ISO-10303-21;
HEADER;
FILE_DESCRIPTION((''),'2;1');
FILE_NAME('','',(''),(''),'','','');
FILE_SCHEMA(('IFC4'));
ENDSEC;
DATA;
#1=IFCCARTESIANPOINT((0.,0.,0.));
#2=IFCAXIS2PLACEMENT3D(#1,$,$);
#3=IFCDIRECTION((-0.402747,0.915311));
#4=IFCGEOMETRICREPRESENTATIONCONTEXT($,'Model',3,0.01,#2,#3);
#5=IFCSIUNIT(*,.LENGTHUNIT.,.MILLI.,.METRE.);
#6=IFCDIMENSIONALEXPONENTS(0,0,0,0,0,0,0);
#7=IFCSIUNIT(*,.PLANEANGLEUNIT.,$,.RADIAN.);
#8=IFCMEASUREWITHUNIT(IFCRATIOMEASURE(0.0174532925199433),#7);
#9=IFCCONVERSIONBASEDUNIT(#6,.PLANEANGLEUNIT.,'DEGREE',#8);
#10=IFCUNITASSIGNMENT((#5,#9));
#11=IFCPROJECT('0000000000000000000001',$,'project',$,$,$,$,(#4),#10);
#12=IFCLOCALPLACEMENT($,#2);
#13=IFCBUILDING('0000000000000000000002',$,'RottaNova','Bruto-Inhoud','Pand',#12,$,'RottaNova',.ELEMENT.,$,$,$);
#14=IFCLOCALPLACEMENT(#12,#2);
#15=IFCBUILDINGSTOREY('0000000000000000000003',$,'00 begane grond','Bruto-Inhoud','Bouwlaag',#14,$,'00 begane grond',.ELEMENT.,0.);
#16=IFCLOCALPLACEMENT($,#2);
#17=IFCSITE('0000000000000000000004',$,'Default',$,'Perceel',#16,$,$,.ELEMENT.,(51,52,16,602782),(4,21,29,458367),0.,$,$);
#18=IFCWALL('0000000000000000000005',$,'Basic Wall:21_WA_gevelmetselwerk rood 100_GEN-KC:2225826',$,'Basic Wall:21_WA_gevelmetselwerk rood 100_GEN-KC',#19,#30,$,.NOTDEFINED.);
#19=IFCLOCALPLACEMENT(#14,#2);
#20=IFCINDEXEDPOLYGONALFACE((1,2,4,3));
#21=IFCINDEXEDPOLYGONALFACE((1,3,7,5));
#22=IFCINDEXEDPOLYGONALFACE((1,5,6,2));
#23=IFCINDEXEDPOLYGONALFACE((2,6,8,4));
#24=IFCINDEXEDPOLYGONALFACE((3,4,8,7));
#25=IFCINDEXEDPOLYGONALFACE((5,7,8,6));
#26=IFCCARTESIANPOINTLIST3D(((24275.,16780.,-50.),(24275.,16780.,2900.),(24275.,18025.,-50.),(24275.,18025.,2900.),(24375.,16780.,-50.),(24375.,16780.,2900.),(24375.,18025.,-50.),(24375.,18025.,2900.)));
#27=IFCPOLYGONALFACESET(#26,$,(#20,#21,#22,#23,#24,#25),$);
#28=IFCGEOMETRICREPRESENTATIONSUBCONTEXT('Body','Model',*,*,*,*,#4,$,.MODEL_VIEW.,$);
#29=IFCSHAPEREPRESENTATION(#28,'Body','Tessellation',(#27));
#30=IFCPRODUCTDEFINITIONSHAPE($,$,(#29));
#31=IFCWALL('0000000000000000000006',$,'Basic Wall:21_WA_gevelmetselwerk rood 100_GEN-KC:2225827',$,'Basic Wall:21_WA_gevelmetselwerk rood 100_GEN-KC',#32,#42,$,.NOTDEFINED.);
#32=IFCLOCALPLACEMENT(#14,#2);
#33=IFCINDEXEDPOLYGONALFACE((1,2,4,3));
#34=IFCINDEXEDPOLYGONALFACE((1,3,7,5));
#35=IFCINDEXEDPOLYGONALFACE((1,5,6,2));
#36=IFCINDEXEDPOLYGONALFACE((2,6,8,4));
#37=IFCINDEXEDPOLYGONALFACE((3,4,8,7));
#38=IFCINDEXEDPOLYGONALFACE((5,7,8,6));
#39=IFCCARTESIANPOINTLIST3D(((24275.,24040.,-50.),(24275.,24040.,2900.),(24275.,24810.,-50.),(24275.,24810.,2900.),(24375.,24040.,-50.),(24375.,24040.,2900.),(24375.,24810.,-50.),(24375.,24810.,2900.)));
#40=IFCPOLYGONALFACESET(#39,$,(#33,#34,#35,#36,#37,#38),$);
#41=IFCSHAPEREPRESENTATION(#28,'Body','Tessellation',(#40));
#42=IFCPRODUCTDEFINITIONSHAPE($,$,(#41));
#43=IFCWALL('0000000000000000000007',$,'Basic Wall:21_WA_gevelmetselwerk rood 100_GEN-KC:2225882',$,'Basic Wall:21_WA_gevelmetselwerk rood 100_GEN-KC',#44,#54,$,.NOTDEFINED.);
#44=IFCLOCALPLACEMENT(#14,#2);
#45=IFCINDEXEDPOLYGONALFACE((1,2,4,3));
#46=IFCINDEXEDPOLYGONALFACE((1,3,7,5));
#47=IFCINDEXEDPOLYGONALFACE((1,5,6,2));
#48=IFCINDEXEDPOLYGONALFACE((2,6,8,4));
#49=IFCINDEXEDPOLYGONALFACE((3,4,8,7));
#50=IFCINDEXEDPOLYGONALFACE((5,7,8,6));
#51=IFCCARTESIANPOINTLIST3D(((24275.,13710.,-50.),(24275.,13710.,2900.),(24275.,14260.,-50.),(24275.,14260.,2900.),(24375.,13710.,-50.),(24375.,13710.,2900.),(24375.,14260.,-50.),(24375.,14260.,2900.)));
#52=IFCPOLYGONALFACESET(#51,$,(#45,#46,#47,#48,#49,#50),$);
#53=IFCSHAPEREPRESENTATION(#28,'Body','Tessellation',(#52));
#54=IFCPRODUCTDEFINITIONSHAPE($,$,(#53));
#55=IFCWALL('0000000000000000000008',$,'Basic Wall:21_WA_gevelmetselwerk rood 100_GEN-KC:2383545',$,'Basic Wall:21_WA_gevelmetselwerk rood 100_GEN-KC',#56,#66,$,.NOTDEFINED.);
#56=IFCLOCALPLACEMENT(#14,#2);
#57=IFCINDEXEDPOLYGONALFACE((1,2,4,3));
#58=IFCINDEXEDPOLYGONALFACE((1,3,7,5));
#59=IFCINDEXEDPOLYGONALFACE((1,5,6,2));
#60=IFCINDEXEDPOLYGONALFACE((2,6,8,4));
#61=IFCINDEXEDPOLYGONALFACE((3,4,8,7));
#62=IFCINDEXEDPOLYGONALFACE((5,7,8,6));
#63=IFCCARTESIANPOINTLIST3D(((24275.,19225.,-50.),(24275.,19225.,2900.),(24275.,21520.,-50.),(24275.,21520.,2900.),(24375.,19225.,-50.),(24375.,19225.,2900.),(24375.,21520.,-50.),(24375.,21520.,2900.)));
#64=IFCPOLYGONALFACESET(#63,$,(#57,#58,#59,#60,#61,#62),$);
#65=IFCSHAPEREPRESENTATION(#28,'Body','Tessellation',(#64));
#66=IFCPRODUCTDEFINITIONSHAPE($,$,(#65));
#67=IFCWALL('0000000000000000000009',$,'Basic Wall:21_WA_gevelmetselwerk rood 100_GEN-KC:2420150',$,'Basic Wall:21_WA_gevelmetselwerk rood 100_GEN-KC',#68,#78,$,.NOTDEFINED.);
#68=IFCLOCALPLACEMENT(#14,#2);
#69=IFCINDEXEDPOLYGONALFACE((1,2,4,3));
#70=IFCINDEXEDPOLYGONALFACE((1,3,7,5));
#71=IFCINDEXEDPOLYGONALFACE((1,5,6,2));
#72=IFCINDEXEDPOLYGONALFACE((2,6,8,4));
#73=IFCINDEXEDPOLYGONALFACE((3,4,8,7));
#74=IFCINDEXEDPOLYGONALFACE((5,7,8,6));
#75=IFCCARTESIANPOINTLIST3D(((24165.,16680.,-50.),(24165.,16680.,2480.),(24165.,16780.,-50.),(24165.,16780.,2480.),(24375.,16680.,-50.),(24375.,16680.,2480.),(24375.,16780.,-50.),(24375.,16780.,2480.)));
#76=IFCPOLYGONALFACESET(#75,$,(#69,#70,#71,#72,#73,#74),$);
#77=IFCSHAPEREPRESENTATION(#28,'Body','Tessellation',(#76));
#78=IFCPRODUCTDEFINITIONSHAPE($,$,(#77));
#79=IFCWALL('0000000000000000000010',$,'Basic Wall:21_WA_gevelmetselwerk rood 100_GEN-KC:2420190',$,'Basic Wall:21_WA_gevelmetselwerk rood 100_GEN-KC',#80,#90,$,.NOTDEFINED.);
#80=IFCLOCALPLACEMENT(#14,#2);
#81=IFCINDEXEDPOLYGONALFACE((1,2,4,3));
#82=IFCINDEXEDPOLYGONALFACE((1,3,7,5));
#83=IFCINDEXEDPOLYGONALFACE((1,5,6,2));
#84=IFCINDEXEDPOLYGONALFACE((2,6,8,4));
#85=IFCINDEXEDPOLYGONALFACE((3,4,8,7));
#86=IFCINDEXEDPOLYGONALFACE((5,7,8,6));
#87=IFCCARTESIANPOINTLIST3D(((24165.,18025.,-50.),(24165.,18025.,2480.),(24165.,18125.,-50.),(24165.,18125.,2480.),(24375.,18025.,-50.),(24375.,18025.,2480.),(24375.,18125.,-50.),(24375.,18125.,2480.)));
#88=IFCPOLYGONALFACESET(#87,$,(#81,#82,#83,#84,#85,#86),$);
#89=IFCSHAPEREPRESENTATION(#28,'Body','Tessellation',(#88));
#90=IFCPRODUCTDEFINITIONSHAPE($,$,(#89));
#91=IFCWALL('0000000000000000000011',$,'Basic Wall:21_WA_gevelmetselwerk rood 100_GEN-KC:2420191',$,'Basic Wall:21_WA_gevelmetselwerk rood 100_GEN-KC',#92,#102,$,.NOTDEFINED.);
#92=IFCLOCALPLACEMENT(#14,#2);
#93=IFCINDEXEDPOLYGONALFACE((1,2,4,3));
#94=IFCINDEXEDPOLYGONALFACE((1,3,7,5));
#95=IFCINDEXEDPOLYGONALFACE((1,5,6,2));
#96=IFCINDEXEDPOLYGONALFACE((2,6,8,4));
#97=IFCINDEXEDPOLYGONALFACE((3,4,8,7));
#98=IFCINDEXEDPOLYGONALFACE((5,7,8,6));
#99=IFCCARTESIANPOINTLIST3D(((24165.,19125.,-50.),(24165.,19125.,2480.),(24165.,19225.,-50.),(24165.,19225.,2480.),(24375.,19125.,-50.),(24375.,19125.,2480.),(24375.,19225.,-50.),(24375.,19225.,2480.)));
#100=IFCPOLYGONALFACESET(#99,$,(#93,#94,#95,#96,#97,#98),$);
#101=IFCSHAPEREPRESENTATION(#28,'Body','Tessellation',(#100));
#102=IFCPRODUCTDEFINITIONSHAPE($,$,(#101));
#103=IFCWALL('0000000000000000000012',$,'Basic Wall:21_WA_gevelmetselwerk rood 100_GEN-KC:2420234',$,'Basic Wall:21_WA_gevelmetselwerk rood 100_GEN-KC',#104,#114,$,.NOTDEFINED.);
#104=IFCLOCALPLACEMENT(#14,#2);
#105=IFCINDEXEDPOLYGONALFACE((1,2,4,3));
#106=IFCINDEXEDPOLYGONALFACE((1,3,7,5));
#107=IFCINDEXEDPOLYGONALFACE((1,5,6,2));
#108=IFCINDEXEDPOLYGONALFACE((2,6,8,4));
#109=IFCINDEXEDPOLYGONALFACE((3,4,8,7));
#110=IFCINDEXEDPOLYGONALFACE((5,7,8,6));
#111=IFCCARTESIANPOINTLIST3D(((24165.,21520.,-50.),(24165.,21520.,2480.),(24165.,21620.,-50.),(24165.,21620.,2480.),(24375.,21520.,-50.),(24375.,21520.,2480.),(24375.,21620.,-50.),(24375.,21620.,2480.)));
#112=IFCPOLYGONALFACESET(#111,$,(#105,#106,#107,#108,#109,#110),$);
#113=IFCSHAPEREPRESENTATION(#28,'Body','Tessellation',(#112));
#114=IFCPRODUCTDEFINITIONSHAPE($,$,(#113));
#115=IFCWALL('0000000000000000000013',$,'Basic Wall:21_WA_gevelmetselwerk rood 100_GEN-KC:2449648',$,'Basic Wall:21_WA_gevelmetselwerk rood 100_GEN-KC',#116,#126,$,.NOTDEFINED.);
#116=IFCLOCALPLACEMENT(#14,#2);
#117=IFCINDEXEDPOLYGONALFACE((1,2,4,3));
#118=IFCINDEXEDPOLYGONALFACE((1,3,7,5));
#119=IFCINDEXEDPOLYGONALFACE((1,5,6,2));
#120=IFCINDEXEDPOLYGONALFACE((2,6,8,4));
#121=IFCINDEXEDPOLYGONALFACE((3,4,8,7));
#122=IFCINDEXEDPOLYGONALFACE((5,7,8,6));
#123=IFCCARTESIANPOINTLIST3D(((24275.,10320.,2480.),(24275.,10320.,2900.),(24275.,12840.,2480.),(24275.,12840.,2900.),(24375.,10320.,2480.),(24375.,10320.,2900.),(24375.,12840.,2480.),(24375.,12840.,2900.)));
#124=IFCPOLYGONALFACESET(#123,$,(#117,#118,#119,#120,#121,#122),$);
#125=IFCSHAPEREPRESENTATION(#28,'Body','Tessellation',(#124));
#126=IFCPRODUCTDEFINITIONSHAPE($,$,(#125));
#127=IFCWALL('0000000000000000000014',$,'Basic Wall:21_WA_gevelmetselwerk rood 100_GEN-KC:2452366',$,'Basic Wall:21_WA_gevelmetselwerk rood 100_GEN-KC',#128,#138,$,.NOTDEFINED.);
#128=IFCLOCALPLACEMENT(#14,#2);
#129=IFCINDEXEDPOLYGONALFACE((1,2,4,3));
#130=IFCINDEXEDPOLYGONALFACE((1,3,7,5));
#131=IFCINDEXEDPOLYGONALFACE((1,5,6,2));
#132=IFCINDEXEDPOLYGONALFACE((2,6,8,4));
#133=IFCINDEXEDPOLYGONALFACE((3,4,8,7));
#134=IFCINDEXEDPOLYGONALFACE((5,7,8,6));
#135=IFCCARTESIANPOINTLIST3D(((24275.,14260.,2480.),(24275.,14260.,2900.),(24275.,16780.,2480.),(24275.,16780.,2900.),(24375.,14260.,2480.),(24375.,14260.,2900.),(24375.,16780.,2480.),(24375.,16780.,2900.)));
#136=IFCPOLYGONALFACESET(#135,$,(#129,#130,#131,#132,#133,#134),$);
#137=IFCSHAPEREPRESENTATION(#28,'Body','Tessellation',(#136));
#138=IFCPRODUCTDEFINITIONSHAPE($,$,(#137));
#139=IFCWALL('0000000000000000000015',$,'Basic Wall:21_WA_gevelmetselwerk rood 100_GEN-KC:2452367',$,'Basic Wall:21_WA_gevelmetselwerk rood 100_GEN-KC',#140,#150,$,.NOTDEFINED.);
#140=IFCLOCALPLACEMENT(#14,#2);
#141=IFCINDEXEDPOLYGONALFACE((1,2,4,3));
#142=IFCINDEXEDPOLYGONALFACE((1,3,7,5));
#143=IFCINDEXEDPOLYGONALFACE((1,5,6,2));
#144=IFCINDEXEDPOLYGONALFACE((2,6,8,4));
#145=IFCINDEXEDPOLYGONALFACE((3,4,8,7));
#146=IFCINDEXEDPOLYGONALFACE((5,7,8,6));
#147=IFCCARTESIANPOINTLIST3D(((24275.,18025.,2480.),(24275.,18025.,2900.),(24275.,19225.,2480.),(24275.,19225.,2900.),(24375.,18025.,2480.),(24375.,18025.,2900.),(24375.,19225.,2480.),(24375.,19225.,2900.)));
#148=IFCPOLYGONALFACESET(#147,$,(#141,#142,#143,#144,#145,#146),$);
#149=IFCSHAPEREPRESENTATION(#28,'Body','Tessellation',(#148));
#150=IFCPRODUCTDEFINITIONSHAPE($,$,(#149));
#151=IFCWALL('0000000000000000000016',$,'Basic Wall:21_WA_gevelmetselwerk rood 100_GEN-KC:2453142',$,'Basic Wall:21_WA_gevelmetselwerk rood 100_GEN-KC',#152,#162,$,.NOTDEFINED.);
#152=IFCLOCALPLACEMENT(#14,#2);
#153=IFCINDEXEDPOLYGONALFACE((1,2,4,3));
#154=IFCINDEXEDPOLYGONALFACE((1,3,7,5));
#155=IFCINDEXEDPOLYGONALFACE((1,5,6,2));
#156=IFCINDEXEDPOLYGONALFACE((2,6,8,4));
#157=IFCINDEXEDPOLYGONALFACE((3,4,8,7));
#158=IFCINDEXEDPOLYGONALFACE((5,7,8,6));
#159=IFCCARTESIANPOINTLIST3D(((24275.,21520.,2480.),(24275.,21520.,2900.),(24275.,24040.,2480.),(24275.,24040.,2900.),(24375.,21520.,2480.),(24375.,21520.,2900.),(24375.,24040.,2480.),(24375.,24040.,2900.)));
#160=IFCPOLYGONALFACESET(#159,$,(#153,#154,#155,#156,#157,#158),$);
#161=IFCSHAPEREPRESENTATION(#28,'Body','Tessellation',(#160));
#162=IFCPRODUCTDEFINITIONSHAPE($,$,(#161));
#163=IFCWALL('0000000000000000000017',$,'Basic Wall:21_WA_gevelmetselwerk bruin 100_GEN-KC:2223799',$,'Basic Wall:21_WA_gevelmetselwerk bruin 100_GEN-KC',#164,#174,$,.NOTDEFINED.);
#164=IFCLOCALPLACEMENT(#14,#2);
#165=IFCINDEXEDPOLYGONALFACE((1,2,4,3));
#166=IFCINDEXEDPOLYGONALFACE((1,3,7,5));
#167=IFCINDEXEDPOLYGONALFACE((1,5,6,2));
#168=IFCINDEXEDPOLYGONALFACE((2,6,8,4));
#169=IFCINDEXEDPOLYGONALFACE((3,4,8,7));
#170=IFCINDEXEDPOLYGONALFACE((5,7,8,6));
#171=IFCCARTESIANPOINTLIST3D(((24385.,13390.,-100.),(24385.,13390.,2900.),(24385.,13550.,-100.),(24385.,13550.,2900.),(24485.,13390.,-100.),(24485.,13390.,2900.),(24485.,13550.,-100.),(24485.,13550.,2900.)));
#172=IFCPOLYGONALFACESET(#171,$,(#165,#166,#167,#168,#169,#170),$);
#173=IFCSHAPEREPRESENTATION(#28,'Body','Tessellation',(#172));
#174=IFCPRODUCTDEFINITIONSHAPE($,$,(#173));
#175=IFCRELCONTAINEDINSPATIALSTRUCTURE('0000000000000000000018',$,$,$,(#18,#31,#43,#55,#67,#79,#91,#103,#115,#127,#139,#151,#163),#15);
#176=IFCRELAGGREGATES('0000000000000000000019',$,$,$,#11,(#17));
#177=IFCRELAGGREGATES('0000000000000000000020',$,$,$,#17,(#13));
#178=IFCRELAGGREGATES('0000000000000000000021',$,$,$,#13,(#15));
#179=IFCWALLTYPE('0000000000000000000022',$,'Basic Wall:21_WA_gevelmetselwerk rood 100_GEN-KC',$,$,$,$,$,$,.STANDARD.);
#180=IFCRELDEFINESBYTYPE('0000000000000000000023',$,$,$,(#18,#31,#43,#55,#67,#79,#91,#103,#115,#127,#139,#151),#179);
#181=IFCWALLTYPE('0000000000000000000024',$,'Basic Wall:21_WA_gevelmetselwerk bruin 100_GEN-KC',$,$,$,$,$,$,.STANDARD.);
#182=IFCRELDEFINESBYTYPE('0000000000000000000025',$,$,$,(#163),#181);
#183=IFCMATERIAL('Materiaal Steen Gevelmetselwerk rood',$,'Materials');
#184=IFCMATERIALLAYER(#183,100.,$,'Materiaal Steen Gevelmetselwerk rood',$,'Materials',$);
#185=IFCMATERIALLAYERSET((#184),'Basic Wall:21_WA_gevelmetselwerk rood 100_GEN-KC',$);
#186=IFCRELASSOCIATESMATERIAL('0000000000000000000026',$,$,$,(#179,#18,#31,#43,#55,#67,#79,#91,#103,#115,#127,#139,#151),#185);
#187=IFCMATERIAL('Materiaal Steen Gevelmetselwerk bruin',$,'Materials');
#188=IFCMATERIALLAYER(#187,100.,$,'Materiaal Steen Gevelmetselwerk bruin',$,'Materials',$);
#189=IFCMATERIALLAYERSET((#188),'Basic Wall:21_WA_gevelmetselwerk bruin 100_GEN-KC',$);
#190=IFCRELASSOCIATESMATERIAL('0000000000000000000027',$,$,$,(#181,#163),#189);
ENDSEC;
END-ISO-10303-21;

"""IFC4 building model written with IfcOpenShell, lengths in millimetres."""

from ifc_helpers import new_model, entity, si_unit, converted_unit, direction, frame, frame_2d, origin, place, context, subcontext, project, spatial, polyline, rectangle, extrude, clip, bounded_halfspace, material, layer, layer_set, type_object, element, save


model = new_model("IFC4")

# Units and contexts
model_context = context("Model", 3, precision=0.01, world=origin(), true_north=direction((-0.402747, 0.915311)))
body_context = subcontext(model_context, "Body", "Model", "MODEL_VIEW")
ifc_project = project(units=[si_unit("LENGTHUNIT", "METRE", prefix="MILLI"), converted_unit("PLANEANGLEUNIT", "DEGREE", entity("IfcRatioMeasure", 0.0174532925199433), si_unit("PLANEANGLEUNIT", "RADIAN"), dimensions=[0, 0, 0, 0, 0, 0, 0])], contexts=[model_context])

# Site, building, storey
site_placement = place(None, origin())
site = spatial("IfcSite", under=ifc_project, at=site_placement, Name="Default", ObjectType="Perceel", CompositionType="ELEMENT", RefLatitude=(51, 52, 16, 602782), RefLongitude=(4, 21, 29, 458367), RefElevation=0.0)
building_placement = place(None, origin())
building = spatial("IfcBuilding", under=site, at=building_placement, Name="RottaNova", Description="Bruto-Inhoud", ObjectType="Pand", LongName="RottaNova", CompositionType="ELEMENT")
storey_placement = place(building_placement, origin())
storey = spatial("IfcBuildingStorey", under=building, at=storey_placement, Name="00 begane grond", Description="Bruto-Inhoud", ObjectType="Bouwlaag", LongName="00 begane grond", CompositionType="ELEMENT", Elevation=0.0)

# Walls
ifc_material_1 = material(Name="Materiaal Steen Gevelmetselwerk rood", Category="Materials")
ifc_layer_1 = layer(ifc_material_1, 100.0, Name="Materiaal Steen Gevelmetselwerk rood", Category="Materials")
ifc_layer_set_1 = layer_set([ifc_layer_1], Name="Basic Wall:21_WA_gevelmetselwerk rood 100_GEN-KC")
wall_type_1 = type_object("IfcWallType", Name="Basic Wall:21_WA_gevelmetselwerk rood 100_GEN-KC", PredefinedType="STANDARD", material=ifc_layer_set_1)
wall_1_placement = place(storey_placement, frame((24325.0, 16780.0, -50.0), z_axis=(0.0, 0.0, 1.0), x_axis=(0.0, 1.0, 0.0)))
element("IfcWall", 1, at=wall_1_placement, inside=storey, type_object=wall_type_1, material=ifc_layer_set_1, Name="Basic Wall:21_WA_gevelmetselwerk rood 100_GEN-KC:2225826", ObjectType="Basic Wall:21_WA_gevelmetselwerk rood 100_GEN-KC", PredefinedType="NOTDEFINED", context=body_context, shape_type="SweptSolid", body=[
    extrude(rectangle(XDim=1245.0, YDim=100.0, at=frame_2d((622.5, 0.0), x_axis=(-1.0, 0.0))), origin(), (0.0, 0.0, 1.0), 2950.0),
])
wall_2_placement = place(storey_placement, frame((24325.0, 24810.0, -50.0), z_axis=(0.0, 0.0, 1.0), x_axis=(0.0, -1.0, 0.0)))
element("IfcWall", 2, at=wall_2_placement, inside=storey, type_object=wall_type_1, material=ifc_layer_set_1, Name="Basic Wall:21_WA_gevelmetselwerk rood 100_GEN-KC:2225827", ObjectType="Basic Wall:21_WA_gevelmetselwerk rood 100_GEN-KC", PredefinedType="NOTDEFINED", context=body_context, shape_type="SweptSolid", body=[
    extrude(rectangle(XDim=770.0, YDim=100.0, at=frame_2d((385.0, 0.0), x_axis=(-1.0, 0.0))), origin(), (0.0, 0.0, 1.0), 2950.0),
])
wall_3_placement = place(storey_placement, frame((24325.0, 13710.0, -50.0), z_axis=(0.0, 0.0, 1.0), x_axis=(0.0, 1.0, 0.0)))
element("IfcWall", 3, at=wall_3_placement, inside=storey, type_object=wall_type_1, material=ifc_layer_set_1, Name="Basic Wall:21_WA_gevelmetselwerk rood 100_GEN-KC:2225882", ObjectType="Basic Wall:21_WA_gevelmetselwerk rood 100_GEN-KC", PredefinedType="NOTDEFINED", context=body_context, shape_type="SweptSolid", body=[
    extrude(rectangle(XDim=550.0, YDim=100.0, at=frame_2d((275.0, 0.0), x_axis=(-1.0, 0.0))), origin(), (0.0, 0.0, 1.0), 2950.0),
])
wall_4_placement = place(storey_placement, frame((24325.0, 19225.0, -50.0), z_axis=(0.0, 0.0, 1.0), x_axis=(0.0, 1.0, 0.0)))
element("IfcWall", 4, at=wall_4_placement, inside=storey, type_object=wall_type_1, material=ifc_layer_set_1, Name="Basic Wall:21_WA_gevelmetselwerk rood 100_GEN-KC:2383545", ObjectType="Basic Wall:21_WA_gevelmetselwerk rood 100_GEN-KC", PredefinedType="NOTDEFINED", context=body_context, shape_type="SweptSolid", body=[
    extrude(rectangle(XDim=2295.0, YDim=100.0, at=frame_2d((1147.5, 0.0), x_axis=(-1.0, 0.0))), origin(), (0.0, 0.0, 1.0), 2950.0),
])
wall_5_placement = place(storey_placement, frame((24375.0, 16730.0, -50.0), z_axis=(0.0, 0.0, 1.0), x_axis=(-1.0, 0.0, 0.0)))
element("IfcWall", 5, at=wall_5_placement, inside=storey, type_object=wall_type_1, material=ifc_layer_set_1, Name="Basic Wall:21_WA_gevelmetselwerk rood 100_GEN-KC:2420150", ObjectType="Basic Wall:21_WA_gevelmetselwerk rood 100_GEN-KC", PredefinedType="NOTDEFINED", context=body_context, shape_type="SweptSolid", body=[
    extrude(rectangle(XDim=210.0, YDim=100.0, at=frame_2d((105.0, 0.0), x_axis=(-1.0, 0.0))), origin(), (0.0, 0.0, 1.0), 2530.0),
])
wall_6_placement = place(storey_placement, frame((24375.0, 18075.0, -50.0), z_axis=(0.0, 0.0, 1.0), x_axis=(-1.0, 0.0, 0.0)))
element("IfcWall", 6, at=wall_6_placement, inside=storey, type_object=wall_type_1, material=ifc_layer_set_1, Name="Basic Wall:21_WA_gevelmetselwerk rood 100_GEN-KC:2420190", ObjectType="Basic Wall:21_WA_gevelmetselwerk rood 100_GEN-KC", PredefinedType="NOTDEFINED", context=body_context, shape_type="SweptSolid", body=[
    extrude(rectangle(XDim=210.0, YDim=100.0, at=frame_2d((105.0, 0.0), x_axis=(-1.0, 0.0))), origin(), (0.0, 0.0, 1.0), 2530.0),
])
wall_7_placement = place(storey_placement, frame((24375.0, 19175.0, -50.0), z_axis=(0.0, 0.0, 1.0), x_axis=(-1.0, 0.0, 0.0)))
element("IfcWall", 7, at=wall_7_placement, inside=storey, type_object=wall_type_1, material=ifc_layer_set_1, Name="Basic Wall:21_WA_gevelmetselwerk rood 100_GEN-KC:2420191", ObjectType="Basic Wall:21_WA_gevelmetselwerk rood 100_GEN-KC", PredefinedType="NOTDEFINED", context=body_context, shape_type="SweptSolid", body=[
    extrude(rectangle(XDim=210.0, YDim=100.0, at=frame_2d((105.0, 0.0), x_axis=(-1.0, 0.0))), origin(), (0.0, 0.0, 1.0), 2530.0),
])
wall_8_placement = place(storey_placement, frame((24375.0, 21570.0, -50.0), z_axis=(0.0, 0.0, 1.0), x_axis=(-1.0, 0.0, 0.0)))
element("IfcWall", 8, at=wall_8_placement, inside=storey, type_object=wall_type_1, material=ifc_layer_set_1, Name="Basic Wall:21_WA_gevelmetselwerk rood 100_GEN-KC:2420234", ObjectType="Basic Wall:21_WA_gevelmetselwerk rood 100_GEN-KC", PredefinedType="NOTDEFINED", context=body_context, shape_type="SweptSolid", body=[
    extrude(rectangle(XDim=210.0, YDim=100.0, at=frame_2d((105.0, 0.0), x_axis=(-1.0, 0.0))), origin(), (0.0, 0.0, 1.0), 2530.0),
])
wall_9_placement = place(storey_placement, frame((24325.0, 12840.0, 2480.0), z_axis=(0.0, 0.0, 1.0), x_axis=(0.0, -1.0, 0.0)))
element("IfcWall", 9, at=wall_9_placement, inside=storey, type_object=wall_type_1, material=ifc_layer_set_1, Name="Basic Wall:21_WA_gevelmetselwerk rood 100_GEN-KC:2449648", ObjectType="Basic Wall:21_WA_gevelmetselwerk rood 100_GEN-KC", PredefinedType="NOTDEFINED", context=body_context, shape_type="SweptSolid", body=[
    extrude(rectangle(XDim=2520.0, YDim=100.0, at=frame_2d((1260.0, 0.0), x_axis=(-1.0, 0.0))), origin(), (0.0, 0.0, 1.0), 420.0),
])
wall_10_placement = place(storey_placement, frame((24325.0, 14260.0, 2480.0), z_axis=(0.0, 0.0, 1.0), x_axis=(0.0, 1.0, 0.0)))
element("IfcWall", 10, at=wall_10_placement, inside=storey, type_object=wall_type_1, material=ifc_layer_set_1, Name="Basic Wall:21_WA_gevelmetselwerk rood 100_GEN-KC:2452366", ObjectType="Basic Wall:21_WA_gevelmetselwerk rood 100_GEN-KC", PredefinedType="NOTDEFINED", context=body_context, shape_type="Clipping", body=[
    clip(extrude(rectangle(XDim=2520.0, YDim=100.0, at=frame_2d((1260.0, 0.0), x_axis=(-1.0, 0.0))), origin(), (0.0, 0.0, 1.0), 420.0), bounded_halfspace(frame((2520.0, -50.0, 420.0), z_axis=(1.0, 0.0, 0.0), x_axis=(0.0, 1.0, 0.0)), False, frame((2520.0, -50.0, 420.0), z_axis=(1.0, 0.0, 0.0), x_axis=(0.0, 1.0, 0.0)), polyline([(0.0, 0.0), (0.0, -128016.0), (30480.0, -128016.0), (30480.0, 0.0), (0.0, 0.0)]))),
])
wall_11_placement = place(storey_placement, frame((24325.0, 19225.0, 2480.0), z_axis=(0.0, 0.0, 1.0), x_axis=(0.0, -1.0, 0.0)))
element("IfcWall", 11, at=wall_11_placement, inside=storey, type_object=wall_type_1, material=ifc_layer_set_1, Name="Basic Wall:21_WA_gevelmetselwerk rood 100_GEN-KC:2452367", ObjectType="Basic Wall:21_WA_gevelmetselwerk rood 100_GEN-KC", PredefinedType="NOTDEFINED", context=body_context, shape_type="Clipping", body=[
    clip(extrude(rectangle(XDim=1200.0, YDim=100.0, at=frame_2d((600.0, 0.0), x_axis=(-1.0, 0.0))), origin(), (0.0, 0.0, 1.0), 420.0), bounded_halfspace(frame((1200.0, -50.0, 420.0), z_axis=(1.0, 0.0, 0.0), x_axis=(0.0, 1.0, 0.0)), False, frame((1200.0, -50.0, 420.0), z_axis=(1.0, 0.0, 0.0), x_axis=(0.0, 1.0, 0.0)), polyline([(0.0, 0.0), (0.0, -128016.0), (30480.0, -128016.0), (30480.0, 0.0), (0.0, 0.0)]))),
])
wall_12_placement = place(storey_placement, frame((24325.0, 24040.0, 2480.0), z_axis=(0.0, 0.0, 1.0), x_axis=(0.0, -1.0, 0.0)))
element("IfcWall", 12, at=wall_12_placement, inside=storey, type_object=wall_type_1, material=ifc_layer_set_1, Name="Basic Wall:21_WA_gevelmetselwerk rood 100_GEN-KC:2453142", ObjectType="Basic Wall:21_WA_gevelmetselwerk rood 100_GEN-KC", PredefinedType="NOTDEFINED", context=body_context, shape_type="Clipping", body=[
    clip(extrude(rectangle(XDim=2520.0, YDim=100.0, at=frame_2d((1260.0, 0.0), x_axis=(-1.0, 0.0))), origin(), (0.0, 0.0, 1.0), 420.0), bounded_halfspace(frame((2520.0, -50.0, 420.0), z_axis=(1.0, 0.0, 0.0), x_axis=(0.0, 1.0, 0.0)), False, frame((2520.0, -50.0, 420.0), z_axis=(1.0, 0.0, 0.0), x_axis=(0.0, 1.0, 0.0)), polyline([(0.0, 0.0), (0.0, -128016.0), (30480.0, -128016.0), (30480.0, 0.0), (0.0, 0.0)]))),
])
ifc_material_2 = material(Name="Materiaal Steen Gevelmetselwerk bruin", Category="Materials")
ifc_layer_2 = layer(ifc_material_2, 100.0, Name="Materiaal Steen Gevelmetselwerk bruin", Category="Materials")
ifc_layer_set_2 = layer_set([ifc_layer_2], Name="Basic Wall:21_WA_gevelmetselwerk bruin 100_GEN-KC")
wall_type_2 = type_object("IfcWallType", Name="Basic Wall:21_WA_gevelmetselwerk bruin 100_GEN-KC", PredefinedType="STANDARD", material=ifc_layer_set_2)
wall_13_placement = place(storey_placement, frame((24435.0, 13550.0, -100.0), z_axis=(0.0, 0.0, 1.0), x_axis=(0.0, -1.0, 0.0)))
element("IfcWall", 13, at=wall_13_placement, inside=storey, type_object=wall_type_2, material=ifc_layer_set_2, Name="Basic Wall:21_WA_gevelmetselwerk bruin 100_GEN-KC:2223799", ObjectType="Basic Wall:21_WA_gevelmetselwerk bruin 100_GEN-KC", PredefinedType="NOTDEFINED", context=body_context, shape_type="SweptSolid", body=[
    extrude(rectangle(XDim=160.0, YDim=100.0, at=frame_2d((80.0, 0.0), x_axis=(-1.0, 0.0))), origin(), (0.0, 0.0, 1.0), 3000.0),
])

save(model, "model.ifc")
